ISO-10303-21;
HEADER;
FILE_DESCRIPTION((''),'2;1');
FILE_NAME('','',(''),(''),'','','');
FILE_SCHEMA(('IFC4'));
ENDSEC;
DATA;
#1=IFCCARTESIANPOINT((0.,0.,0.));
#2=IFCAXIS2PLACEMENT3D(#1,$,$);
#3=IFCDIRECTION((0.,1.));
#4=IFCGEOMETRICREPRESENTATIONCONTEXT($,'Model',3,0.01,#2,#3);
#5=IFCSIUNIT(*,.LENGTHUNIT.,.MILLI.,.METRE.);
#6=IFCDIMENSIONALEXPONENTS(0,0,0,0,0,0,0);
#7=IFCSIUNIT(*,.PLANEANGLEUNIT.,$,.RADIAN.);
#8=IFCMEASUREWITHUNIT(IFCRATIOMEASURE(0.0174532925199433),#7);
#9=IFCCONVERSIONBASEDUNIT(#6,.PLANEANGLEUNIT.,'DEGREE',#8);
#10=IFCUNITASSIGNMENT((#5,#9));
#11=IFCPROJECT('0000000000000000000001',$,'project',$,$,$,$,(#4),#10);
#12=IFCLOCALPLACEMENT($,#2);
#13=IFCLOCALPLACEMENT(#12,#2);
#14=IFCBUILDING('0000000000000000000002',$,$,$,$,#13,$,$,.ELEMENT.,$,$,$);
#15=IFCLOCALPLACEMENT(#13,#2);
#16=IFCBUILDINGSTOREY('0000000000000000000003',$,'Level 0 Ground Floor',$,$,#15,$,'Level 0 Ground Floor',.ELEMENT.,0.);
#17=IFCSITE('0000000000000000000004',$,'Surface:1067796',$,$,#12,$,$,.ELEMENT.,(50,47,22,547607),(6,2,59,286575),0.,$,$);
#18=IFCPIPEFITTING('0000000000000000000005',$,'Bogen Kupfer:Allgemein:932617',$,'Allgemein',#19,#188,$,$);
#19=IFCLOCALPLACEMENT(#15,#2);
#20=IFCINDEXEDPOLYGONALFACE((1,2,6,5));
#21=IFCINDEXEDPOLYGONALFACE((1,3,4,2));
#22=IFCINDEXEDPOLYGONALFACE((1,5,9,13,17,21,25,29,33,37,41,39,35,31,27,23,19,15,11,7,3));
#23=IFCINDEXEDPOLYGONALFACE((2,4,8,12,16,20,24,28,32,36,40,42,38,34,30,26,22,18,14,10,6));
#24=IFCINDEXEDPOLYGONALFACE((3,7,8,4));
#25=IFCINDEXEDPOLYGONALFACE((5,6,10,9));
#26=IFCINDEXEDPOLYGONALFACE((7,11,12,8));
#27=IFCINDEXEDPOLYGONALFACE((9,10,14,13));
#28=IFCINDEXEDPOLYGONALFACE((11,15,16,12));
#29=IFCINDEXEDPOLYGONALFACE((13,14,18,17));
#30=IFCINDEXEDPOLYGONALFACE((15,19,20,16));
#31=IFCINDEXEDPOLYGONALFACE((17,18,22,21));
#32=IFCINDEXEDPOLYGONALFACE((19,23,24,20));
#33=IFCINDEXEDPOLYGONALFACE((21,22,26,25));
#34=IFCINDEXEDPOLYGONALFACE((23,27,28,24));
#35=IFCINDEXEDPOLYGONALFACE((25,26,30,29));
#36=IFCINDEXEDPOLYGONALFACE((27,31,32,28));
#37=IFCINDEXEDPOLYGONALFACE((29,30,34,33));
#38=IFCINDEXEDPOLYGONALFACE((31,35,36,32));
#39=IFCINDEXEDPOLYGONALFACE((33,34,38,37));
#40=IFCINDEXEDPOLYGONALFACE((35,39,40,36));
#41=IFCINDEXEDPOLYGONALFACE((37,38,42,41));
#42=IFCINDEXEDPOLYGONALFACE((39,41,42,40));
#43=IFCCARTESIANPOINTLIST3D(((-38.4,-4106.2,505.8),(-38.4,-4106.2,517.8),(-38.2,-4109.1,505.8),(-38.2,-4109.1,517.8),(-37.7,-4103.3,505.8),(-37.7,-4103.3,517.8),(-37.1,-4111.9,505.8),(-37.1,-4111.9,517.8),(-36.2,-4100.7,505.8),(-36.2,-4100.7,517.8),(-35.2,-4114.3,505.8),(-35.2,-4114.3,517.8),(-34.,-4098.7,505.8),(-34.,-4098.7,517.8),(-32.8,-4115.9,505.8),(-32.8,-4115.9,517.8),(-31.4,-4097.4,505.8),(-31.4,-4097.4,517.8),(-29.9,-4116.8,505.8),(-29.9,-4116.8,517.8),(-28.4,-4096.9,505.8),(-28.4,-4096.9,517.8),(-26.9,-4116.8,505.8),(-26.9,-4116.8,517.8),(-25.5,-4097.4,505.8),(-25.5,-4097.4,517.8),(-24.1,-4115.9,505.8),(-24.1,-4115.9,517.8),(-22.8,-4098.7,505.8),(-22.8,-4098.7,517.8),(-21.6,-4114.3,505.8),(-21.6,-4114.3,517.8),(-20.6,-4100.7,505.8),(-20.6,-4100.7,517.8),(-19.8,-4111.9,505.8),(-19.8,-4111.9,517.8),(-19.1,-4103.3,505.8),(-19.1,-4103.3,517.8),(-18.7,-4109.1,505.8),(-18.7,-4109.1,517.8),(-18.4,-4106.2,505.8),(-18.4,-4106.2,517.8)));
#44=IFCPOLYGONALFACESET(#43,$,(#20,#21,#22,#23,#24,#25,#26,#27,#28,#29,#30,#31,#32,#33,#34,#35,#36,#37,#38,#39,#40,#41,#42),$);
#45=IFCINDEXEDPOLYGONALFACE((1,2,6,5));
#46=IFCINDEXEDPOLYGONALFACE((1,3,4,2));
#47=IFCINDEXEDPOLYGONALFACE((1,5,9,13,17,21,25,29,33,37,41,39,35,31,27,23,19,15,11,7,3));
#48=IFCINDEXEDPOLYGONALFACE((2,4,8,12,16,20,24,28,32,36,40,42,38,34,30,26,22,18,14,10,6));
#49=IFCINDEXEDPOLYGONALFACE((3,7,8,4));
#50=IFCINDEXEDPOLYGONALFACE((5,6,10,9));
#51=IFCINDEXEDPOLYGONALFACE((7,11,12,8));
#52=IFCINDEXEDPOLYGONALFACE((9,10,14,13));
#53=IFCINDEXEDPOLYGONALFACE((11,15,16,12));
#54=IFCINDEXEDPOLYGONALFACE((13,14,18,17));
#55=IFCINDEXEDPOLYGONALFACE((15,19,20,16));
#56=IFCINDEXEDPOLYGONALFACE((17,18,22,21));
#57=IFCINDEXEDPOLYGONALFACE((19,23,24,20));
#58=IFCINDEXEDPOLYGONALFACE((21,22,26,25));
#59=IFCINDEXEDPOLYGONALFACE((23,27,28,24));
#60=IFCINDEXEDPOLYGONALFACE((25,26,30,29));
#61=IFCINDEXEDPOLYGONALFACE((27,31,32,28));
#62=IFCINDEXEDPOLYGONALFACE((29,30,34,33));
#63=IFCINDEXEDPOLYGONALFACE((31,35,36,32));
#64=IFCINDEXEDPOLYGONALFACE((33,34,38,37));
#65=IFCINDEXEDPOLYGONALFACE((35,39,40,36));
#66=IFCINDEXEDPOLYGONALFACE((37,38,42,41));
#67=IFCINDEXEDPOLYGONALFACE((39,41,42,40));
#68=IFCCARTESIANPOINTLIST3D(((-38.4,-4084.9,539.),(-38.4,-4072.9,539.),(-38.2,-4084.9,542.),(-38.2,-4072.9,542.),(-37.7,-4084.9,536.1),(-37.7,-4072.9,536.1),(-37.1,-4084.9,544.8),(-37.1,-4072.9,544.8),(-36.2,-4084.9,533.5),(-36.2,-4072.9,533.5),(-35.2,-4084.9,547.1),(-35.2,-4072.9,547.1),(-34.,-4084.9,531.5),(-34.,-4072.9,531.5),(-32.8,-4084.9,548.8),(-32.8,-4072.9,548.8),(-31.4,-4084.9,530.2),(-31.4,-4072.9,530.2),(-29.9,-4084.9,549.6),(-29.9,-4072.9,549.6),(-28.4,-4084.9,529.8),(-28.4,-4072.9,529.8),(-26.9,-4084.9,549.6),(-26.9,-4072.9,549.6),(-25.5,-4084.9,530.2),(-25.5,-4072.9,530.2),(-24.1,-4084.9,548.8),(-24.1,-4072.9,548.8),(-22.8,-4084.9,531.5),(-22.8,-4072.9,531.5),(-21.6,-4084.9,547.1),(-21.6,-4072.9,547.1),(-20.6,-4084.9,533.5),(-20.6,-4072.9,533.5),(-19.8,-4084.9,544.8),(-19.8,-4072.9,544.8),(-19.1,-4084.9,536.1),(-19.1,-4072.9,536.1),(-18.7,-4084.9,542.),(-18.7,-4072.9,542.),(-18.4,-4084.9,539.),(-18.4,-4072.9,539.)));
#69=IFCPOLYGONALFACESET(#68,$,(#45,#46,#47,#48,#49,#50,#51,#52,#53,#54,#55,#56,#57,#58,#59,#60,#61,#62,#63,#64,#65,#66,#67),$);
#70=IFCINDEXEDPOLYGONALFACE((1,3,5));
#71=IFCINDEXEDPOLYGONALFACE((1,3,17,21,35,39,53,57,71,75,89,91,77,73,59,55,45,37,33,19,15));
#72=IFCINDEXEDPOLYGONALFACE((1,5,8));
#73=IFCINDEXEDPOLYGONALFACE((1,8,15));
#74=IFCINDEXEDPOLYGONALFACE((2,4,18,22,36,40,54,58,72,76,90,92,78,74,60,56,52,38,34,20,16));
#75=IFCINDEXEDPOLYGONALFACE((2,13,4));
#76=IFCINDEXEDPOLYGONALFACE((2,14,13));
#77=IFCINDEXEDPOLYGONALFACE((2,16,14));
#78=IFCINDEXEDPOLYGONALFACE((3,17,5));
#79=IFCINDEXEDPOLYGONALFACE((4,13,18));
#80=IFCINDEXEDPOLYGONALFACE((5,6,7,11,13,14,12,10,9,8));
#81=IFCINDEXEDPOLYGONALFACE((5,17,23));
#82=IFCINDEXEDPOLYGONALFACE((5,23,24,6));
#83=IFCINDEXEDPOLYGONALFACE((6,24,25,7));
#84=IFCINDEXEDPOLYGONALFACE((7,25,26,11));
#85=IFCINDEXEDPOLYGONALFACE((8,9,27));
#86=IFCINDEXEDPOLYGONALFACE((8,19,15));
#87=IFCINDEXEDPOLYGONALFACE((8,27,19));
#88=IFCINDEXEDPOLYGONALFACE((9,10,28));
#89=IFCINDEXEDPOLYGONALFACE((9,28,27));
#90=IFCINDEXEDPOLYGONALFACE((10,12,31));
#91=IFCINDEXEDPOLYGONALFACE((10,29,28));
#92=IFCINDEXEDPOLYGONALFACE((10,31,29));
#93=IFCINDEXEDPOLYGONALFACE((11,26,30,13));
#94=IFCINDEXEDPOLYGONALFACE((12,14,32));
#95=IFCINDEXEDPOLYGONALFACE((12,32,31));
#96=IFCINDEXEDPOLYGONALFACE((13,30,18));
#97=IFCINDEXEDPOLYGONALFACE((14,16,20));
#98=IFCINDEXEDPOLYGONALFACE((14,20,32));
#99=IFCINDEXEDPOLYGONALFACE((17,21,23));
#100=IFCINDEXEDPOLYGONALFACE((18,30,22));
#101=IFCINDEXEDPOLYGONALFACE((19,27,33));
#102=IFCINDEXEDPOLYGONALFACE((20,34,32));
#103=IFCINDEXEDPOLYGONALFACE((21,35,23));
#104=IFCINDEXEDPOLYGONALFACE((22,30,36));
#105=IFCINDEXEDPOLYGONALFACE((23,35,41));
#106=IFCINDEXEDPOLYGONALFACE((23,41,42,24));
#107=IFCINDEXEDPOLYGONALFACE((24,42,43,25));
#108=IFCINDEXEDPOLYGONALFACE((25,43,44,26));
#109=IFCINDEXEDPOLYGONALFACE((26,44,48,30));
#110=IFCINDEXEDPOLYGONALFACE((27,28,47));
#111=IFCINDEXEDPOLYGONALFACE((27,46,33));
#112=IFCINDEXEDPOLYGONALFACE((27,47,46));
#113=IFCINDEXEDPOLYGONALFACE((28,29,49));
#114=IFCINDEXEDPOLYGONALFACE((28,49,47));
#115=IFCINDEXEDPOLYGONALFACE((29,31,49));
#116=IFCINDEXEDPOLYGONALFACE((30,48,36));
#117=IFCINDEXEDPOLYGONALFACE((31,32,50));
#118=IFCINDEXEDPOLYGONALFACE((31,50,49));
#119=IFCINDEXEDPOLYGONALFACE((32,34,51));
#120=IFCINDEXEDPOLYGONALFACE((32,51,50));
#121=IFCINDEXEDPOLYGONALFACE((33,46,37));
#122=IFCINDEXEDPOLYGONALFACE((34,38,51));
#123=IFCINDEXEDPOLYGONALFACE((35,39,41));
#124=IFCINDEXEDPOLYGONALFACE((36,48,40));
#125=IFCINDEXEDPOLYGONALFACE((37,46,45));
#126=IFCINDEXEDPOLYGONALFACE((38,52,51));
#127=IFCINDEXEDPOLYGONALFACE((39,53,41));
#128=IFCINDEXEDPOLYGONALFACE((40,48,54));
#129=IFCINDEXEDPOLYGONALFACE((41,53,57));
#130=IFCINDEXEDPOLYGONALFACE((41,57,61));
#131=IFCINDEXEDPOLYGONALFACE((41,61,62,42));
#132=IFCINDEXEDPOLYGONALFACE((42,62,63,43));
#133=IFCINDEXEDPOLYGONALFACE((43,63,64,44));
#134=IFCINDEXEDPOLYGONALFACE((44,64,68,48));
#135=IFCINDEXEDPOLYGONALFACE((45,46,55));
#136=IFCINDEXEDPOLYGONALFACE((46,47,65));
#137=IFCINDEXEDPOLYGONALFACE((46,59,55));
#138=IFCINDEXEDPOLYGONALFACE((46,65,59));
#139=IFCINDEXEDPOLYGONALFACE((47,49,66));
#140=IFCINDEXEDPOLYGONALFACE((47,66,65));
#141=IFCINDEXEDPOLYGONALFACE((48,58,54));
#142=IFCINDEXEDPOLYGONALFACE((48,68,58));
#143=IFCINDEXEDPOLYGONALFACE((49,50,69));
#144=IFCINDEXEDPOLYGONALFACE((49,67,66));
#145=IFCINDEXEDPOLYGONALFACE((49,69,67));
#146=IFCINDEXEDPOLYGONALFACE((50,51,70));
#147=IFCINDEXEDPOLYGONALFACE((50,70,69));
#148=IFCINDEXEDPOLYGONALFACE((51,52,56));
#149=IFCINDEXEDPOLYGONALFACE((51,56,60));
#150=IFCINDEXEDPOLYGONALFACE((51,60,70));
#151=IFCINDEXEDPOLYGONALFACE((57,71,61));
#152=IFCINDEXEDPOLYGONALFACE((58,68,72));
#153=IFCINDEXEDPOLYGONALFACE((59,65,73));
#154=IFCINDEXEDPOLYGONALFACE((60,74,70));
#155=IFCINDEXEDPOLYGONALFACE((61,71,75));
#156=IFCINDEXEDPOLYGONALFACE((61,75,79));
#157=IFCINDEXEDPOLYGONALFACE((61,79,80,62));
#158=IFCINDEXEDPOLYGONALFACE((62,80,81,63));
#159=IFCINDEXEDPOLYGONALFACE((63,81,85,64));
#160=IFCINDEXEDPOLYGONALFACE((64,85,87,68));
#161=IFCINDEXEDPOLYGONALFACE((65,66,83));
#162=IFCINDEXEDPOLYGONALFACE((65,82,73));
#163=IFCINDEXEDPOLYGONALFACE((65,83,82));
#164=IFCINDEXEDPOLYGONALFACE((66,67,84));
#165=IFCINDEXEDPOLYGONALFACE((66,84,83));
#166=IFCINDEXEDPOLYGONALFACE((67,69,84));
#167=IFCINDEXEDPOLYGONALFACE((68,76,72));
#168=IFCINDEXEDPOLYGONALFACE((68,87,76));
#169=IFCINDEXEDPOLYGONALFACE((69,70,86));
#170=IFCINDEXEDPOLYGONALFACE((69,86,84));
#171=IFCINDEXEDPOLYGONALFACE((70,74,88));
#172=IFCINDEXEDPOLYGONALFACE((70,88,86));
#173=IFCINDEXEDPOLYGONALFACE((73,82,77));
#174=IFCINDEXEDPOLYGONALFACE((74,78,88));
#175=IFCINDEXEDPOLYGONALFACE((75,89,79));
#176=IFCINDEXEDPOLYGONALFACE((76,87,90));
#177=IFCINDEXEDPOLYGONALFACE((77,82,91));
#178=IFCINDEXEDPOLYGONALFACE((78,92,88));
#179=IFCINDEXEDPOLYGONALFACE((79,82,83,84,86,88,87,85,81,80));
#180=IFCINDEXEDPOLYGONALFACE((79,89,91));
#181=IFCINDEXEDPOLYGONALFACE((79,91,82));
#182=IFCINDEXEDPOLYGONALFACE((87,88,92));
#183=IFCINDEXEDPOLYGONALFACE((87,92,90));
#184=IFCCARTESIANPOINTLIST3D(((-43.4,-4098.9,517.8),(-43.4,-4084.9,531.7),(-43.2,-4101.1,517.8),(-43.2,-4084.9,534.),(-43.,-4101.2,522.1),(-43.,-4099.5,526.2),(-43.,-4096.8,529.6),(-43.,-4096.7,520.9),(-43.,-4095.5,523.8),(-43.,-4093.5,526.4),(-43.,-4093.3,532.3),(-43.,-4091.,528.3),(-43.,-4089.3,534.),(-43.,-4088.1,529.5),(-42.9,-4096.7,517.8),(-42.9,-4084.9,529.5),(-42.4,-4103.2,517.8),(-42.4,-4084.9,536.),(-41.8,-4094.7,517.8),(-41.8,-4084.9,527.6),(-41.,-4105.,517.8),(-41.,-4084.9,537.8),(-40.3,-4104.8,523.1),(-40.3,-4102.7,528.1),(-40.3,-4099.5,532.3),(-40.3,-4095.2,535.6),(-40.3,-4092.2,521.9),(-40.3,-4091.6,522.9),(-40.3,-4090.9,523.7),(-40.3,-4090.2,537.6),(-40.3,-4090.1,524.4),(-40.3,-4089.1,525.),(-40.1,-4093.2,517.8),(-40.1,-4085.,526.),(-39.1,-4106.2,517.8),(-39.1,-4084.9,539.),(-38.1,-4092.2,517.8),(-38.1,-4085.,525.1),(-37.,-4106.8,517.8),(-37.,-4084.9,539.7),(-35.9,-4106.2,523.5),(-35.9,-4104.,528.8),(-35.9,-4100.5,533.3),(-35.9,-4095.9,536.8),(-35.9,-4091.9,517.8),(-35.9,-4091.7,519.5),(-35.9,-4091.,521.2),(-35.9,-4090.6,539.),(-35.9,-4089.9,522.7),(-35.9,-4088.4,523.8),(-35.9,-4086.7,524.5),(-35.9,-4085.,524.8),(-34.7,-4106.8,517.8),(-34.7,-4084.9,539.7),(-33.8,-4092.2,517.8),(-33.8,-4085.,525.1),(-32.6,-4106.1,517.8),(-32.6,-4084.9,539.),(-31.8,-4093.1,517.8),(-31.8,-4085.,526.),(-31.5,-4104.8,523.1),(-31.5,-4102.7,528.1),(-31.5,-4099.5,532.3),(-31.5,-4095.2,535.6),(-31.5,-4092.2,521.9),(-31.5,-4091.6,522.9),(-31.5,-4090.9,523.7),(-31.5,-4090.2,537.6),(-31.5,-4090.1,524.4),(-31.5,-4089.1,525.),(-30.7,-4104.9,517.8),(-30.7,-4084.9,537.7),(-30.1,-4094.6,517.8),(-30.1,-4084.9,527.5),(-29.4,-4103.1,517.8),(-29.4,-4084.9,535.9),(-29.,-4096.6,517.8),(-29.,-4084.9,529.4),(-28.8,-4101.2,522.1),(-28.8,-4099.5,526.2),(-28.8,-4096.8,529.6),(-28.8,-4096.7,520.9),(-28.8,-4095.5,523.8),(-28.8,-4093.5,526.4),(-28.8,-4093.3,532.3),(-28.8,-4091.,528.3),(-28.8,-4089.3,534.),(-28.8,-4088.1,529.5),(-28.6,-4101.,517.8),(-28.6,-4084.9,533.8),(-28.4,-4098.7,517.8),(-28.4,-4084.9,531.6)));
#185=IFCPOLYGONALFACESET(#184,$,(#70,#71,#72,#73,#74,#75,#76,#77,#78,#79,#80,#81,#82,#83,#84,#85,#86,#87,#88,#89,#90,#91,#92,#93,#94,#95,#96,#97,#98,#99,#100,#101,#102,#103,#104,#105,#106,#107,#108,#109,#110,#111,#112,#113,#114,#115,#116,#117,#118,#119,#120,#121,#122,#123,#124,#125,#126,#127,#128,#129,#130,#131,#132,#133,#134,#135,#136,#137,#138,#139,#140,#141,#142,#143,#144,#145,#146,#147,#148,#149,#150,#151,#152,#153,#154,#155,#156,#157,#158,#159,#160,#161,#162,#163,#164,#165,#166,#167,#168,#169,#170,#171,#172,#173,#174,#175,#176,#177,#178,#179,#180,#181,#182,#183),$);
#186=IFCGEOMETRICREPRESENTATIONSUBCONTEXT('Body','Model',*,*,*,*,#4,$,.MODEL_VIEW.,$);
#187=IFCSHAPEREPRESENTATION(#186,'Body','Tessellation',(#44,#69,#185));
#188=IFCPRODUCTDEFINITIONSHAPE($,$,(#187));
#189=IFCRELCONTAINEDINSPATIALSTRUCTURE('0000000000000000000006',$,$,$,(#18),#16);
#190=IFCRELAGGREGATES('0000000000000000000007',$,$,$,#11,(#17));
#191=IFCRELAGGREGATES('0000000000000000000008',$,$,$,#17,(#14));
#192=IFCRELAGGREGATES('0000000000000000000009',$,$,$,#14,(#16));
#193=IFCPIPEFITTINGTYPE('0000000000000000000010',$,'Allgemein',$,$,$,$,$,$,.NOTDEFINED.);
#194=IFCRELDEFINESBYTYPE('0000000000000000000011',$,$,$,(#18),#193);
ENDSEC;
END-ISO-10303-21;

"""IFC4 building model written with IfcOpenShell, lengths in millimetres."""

from ifc_helpers import new_model, entity, si_unit, converted_unit, direction, frame, frame_2d, origin, place, context, subcontext, project, spatial, circle, extrude, source, transform, mapped, type_object, type_shapes, element, save


model = new_model("IFC4")

# Units and contexts
model_context = context("Model", 3, precision=0.01, world=origin(), true_north=direction((0.0, 1.0)))
body_context = subcontext(model_context, "Body", "Model", "MODEL_VIEW")
ifc_project = project(units=[si_unit("LENGTHUNIT", "METRE", prefix="MILLI"), converted_unit("PLANEANGLEUNIT", "DEGREE", entity("IfcRatioMeasure", 0.0174532925199433), si_unit("PLANEANGLEUNIT", "RADIAN"), dimensions=[0, 0, 0, 0, 0, 0, 0])], contexts=[model_context])

# Site, building, storey
site_placement = place(None, origin())
site = spatial("IfcSite", under=ifc_project, at=site_placement, Name="Surface:1067796", CompositionType="ELEMENT", RefLatitude=(50, 47, 22, 547607), RefLongitude=(6, 2, 59, 286575), RefElevation=0.0)
building_placement = place(site_placement, origin())
building = spatial("IfcBuilding", under=site, at=building_placement, CompositionType="ELEMENT")
storey_placement = place(building_placement, origin())
storey = spatial("IfcBuildingStorey", under=building, at=storey_placement, Name="Level 0 Ground Floor", LongName="Level 0 Ground Floor", CompositionType="ELEMENT", Elevation=0.0)

# Pipe fitting
pipe_fitting_type_1 = type_object("IfcPipeFittingType", Name="Allgemein", PredefinedType="NOTDEFINED")
ifc_direction = entity("IfcDirection", [0.0, 0.0, -1.0])
trimmed_curve = entity("IfcTrimmedCurve", entity("IfcCircle", entity("IfcAxis2Placement2D", entity("IfcCartesianPoint", [-14.5, 0.0]), entity("IfcDirection", [0.0, 1.0])), 14.5), [entity("IfcParameterValue", 270.0)], [entity("IfcParameterValue", 0.0)], True, "PARAMETER")
shared_shape_1 = source(origin(), body_context, "Body", "SolidModel", [
    extrude(circle(Radius=10.0, at=frame_2d((0.0, 0.0), x_axis=(1.0, 0.0))), frame((0.0, 22.0, 0.0), z_axis=(0.0, 1.0, 0.0), x_axis=(-1.0, 0.0, 0.0)), (0.0, 0.0, 1.0), 12.0),
    extrude(circle(Radius=10.0, at=frame_2d((0.0, 0.0), x_axis=(1.0, 0.0))), frame((-34.0, 0.0, 0.0), z_axis=(1.0, 0.0, 0.0), x_axis=(0.0, 1.0, 0.0)), (0.0, 0.0, 1.0), 12.0),
    entity("IfcSurfaceCurveSweptAreaSolid", entity("IfcCircleProfileDef", "AREA", None, entity("IfcAxis2Placement2D", entity("IfcCartesianPoint", [0.0, 7.5]), entity("IfcDirection", [1.0, 0.0])), 7.5), entity("IfcAxis2Placement3D", entity("IfcCartesianPoint", [-7.5, 22.0, 0.0]), ifc_direction, entity("IfcDirection", [1.0, 0.0, 0.0])), trimmed_curve, 0.0, 90.0, entity("IfcSurfaceOfLinearExtrusion", entity("IfcArbitraryOpenProfileDef", "CURVE", None, trimmed_curve), entity("IfcAxis2Placement3D", entity("IfcCartesianPoint", [0.0, 0.0, -304.8])), ifc_direction, 1.0)),
])
type_shapes(pipe_fitting_type_1, [shared_shape_1])
for number, where, z_axis, x_axis, name in (
    (1, (-28.4, -4106.9, 539.8), (1.0, 0.0, 0.0), (0.0, -1.0, 0.0), "Bogen Kupfer:Allgemein:932617"),
):
    element("IfcPipeFitting", number, at=place(storey_placement, frame(where, z_axis=z_axis, x_axis=x_axis)), inside=storey, type_object=pipe_fitting_type_1, Name=name, ObjectType="Allgemein", context=body_context, shape_type="MappedRepresentation", body=[
        mapped(shared_shape_1, transform((0.0, 0.0, 0.0), scale=1.0)),
    ])

save(model, "model.ifc")
